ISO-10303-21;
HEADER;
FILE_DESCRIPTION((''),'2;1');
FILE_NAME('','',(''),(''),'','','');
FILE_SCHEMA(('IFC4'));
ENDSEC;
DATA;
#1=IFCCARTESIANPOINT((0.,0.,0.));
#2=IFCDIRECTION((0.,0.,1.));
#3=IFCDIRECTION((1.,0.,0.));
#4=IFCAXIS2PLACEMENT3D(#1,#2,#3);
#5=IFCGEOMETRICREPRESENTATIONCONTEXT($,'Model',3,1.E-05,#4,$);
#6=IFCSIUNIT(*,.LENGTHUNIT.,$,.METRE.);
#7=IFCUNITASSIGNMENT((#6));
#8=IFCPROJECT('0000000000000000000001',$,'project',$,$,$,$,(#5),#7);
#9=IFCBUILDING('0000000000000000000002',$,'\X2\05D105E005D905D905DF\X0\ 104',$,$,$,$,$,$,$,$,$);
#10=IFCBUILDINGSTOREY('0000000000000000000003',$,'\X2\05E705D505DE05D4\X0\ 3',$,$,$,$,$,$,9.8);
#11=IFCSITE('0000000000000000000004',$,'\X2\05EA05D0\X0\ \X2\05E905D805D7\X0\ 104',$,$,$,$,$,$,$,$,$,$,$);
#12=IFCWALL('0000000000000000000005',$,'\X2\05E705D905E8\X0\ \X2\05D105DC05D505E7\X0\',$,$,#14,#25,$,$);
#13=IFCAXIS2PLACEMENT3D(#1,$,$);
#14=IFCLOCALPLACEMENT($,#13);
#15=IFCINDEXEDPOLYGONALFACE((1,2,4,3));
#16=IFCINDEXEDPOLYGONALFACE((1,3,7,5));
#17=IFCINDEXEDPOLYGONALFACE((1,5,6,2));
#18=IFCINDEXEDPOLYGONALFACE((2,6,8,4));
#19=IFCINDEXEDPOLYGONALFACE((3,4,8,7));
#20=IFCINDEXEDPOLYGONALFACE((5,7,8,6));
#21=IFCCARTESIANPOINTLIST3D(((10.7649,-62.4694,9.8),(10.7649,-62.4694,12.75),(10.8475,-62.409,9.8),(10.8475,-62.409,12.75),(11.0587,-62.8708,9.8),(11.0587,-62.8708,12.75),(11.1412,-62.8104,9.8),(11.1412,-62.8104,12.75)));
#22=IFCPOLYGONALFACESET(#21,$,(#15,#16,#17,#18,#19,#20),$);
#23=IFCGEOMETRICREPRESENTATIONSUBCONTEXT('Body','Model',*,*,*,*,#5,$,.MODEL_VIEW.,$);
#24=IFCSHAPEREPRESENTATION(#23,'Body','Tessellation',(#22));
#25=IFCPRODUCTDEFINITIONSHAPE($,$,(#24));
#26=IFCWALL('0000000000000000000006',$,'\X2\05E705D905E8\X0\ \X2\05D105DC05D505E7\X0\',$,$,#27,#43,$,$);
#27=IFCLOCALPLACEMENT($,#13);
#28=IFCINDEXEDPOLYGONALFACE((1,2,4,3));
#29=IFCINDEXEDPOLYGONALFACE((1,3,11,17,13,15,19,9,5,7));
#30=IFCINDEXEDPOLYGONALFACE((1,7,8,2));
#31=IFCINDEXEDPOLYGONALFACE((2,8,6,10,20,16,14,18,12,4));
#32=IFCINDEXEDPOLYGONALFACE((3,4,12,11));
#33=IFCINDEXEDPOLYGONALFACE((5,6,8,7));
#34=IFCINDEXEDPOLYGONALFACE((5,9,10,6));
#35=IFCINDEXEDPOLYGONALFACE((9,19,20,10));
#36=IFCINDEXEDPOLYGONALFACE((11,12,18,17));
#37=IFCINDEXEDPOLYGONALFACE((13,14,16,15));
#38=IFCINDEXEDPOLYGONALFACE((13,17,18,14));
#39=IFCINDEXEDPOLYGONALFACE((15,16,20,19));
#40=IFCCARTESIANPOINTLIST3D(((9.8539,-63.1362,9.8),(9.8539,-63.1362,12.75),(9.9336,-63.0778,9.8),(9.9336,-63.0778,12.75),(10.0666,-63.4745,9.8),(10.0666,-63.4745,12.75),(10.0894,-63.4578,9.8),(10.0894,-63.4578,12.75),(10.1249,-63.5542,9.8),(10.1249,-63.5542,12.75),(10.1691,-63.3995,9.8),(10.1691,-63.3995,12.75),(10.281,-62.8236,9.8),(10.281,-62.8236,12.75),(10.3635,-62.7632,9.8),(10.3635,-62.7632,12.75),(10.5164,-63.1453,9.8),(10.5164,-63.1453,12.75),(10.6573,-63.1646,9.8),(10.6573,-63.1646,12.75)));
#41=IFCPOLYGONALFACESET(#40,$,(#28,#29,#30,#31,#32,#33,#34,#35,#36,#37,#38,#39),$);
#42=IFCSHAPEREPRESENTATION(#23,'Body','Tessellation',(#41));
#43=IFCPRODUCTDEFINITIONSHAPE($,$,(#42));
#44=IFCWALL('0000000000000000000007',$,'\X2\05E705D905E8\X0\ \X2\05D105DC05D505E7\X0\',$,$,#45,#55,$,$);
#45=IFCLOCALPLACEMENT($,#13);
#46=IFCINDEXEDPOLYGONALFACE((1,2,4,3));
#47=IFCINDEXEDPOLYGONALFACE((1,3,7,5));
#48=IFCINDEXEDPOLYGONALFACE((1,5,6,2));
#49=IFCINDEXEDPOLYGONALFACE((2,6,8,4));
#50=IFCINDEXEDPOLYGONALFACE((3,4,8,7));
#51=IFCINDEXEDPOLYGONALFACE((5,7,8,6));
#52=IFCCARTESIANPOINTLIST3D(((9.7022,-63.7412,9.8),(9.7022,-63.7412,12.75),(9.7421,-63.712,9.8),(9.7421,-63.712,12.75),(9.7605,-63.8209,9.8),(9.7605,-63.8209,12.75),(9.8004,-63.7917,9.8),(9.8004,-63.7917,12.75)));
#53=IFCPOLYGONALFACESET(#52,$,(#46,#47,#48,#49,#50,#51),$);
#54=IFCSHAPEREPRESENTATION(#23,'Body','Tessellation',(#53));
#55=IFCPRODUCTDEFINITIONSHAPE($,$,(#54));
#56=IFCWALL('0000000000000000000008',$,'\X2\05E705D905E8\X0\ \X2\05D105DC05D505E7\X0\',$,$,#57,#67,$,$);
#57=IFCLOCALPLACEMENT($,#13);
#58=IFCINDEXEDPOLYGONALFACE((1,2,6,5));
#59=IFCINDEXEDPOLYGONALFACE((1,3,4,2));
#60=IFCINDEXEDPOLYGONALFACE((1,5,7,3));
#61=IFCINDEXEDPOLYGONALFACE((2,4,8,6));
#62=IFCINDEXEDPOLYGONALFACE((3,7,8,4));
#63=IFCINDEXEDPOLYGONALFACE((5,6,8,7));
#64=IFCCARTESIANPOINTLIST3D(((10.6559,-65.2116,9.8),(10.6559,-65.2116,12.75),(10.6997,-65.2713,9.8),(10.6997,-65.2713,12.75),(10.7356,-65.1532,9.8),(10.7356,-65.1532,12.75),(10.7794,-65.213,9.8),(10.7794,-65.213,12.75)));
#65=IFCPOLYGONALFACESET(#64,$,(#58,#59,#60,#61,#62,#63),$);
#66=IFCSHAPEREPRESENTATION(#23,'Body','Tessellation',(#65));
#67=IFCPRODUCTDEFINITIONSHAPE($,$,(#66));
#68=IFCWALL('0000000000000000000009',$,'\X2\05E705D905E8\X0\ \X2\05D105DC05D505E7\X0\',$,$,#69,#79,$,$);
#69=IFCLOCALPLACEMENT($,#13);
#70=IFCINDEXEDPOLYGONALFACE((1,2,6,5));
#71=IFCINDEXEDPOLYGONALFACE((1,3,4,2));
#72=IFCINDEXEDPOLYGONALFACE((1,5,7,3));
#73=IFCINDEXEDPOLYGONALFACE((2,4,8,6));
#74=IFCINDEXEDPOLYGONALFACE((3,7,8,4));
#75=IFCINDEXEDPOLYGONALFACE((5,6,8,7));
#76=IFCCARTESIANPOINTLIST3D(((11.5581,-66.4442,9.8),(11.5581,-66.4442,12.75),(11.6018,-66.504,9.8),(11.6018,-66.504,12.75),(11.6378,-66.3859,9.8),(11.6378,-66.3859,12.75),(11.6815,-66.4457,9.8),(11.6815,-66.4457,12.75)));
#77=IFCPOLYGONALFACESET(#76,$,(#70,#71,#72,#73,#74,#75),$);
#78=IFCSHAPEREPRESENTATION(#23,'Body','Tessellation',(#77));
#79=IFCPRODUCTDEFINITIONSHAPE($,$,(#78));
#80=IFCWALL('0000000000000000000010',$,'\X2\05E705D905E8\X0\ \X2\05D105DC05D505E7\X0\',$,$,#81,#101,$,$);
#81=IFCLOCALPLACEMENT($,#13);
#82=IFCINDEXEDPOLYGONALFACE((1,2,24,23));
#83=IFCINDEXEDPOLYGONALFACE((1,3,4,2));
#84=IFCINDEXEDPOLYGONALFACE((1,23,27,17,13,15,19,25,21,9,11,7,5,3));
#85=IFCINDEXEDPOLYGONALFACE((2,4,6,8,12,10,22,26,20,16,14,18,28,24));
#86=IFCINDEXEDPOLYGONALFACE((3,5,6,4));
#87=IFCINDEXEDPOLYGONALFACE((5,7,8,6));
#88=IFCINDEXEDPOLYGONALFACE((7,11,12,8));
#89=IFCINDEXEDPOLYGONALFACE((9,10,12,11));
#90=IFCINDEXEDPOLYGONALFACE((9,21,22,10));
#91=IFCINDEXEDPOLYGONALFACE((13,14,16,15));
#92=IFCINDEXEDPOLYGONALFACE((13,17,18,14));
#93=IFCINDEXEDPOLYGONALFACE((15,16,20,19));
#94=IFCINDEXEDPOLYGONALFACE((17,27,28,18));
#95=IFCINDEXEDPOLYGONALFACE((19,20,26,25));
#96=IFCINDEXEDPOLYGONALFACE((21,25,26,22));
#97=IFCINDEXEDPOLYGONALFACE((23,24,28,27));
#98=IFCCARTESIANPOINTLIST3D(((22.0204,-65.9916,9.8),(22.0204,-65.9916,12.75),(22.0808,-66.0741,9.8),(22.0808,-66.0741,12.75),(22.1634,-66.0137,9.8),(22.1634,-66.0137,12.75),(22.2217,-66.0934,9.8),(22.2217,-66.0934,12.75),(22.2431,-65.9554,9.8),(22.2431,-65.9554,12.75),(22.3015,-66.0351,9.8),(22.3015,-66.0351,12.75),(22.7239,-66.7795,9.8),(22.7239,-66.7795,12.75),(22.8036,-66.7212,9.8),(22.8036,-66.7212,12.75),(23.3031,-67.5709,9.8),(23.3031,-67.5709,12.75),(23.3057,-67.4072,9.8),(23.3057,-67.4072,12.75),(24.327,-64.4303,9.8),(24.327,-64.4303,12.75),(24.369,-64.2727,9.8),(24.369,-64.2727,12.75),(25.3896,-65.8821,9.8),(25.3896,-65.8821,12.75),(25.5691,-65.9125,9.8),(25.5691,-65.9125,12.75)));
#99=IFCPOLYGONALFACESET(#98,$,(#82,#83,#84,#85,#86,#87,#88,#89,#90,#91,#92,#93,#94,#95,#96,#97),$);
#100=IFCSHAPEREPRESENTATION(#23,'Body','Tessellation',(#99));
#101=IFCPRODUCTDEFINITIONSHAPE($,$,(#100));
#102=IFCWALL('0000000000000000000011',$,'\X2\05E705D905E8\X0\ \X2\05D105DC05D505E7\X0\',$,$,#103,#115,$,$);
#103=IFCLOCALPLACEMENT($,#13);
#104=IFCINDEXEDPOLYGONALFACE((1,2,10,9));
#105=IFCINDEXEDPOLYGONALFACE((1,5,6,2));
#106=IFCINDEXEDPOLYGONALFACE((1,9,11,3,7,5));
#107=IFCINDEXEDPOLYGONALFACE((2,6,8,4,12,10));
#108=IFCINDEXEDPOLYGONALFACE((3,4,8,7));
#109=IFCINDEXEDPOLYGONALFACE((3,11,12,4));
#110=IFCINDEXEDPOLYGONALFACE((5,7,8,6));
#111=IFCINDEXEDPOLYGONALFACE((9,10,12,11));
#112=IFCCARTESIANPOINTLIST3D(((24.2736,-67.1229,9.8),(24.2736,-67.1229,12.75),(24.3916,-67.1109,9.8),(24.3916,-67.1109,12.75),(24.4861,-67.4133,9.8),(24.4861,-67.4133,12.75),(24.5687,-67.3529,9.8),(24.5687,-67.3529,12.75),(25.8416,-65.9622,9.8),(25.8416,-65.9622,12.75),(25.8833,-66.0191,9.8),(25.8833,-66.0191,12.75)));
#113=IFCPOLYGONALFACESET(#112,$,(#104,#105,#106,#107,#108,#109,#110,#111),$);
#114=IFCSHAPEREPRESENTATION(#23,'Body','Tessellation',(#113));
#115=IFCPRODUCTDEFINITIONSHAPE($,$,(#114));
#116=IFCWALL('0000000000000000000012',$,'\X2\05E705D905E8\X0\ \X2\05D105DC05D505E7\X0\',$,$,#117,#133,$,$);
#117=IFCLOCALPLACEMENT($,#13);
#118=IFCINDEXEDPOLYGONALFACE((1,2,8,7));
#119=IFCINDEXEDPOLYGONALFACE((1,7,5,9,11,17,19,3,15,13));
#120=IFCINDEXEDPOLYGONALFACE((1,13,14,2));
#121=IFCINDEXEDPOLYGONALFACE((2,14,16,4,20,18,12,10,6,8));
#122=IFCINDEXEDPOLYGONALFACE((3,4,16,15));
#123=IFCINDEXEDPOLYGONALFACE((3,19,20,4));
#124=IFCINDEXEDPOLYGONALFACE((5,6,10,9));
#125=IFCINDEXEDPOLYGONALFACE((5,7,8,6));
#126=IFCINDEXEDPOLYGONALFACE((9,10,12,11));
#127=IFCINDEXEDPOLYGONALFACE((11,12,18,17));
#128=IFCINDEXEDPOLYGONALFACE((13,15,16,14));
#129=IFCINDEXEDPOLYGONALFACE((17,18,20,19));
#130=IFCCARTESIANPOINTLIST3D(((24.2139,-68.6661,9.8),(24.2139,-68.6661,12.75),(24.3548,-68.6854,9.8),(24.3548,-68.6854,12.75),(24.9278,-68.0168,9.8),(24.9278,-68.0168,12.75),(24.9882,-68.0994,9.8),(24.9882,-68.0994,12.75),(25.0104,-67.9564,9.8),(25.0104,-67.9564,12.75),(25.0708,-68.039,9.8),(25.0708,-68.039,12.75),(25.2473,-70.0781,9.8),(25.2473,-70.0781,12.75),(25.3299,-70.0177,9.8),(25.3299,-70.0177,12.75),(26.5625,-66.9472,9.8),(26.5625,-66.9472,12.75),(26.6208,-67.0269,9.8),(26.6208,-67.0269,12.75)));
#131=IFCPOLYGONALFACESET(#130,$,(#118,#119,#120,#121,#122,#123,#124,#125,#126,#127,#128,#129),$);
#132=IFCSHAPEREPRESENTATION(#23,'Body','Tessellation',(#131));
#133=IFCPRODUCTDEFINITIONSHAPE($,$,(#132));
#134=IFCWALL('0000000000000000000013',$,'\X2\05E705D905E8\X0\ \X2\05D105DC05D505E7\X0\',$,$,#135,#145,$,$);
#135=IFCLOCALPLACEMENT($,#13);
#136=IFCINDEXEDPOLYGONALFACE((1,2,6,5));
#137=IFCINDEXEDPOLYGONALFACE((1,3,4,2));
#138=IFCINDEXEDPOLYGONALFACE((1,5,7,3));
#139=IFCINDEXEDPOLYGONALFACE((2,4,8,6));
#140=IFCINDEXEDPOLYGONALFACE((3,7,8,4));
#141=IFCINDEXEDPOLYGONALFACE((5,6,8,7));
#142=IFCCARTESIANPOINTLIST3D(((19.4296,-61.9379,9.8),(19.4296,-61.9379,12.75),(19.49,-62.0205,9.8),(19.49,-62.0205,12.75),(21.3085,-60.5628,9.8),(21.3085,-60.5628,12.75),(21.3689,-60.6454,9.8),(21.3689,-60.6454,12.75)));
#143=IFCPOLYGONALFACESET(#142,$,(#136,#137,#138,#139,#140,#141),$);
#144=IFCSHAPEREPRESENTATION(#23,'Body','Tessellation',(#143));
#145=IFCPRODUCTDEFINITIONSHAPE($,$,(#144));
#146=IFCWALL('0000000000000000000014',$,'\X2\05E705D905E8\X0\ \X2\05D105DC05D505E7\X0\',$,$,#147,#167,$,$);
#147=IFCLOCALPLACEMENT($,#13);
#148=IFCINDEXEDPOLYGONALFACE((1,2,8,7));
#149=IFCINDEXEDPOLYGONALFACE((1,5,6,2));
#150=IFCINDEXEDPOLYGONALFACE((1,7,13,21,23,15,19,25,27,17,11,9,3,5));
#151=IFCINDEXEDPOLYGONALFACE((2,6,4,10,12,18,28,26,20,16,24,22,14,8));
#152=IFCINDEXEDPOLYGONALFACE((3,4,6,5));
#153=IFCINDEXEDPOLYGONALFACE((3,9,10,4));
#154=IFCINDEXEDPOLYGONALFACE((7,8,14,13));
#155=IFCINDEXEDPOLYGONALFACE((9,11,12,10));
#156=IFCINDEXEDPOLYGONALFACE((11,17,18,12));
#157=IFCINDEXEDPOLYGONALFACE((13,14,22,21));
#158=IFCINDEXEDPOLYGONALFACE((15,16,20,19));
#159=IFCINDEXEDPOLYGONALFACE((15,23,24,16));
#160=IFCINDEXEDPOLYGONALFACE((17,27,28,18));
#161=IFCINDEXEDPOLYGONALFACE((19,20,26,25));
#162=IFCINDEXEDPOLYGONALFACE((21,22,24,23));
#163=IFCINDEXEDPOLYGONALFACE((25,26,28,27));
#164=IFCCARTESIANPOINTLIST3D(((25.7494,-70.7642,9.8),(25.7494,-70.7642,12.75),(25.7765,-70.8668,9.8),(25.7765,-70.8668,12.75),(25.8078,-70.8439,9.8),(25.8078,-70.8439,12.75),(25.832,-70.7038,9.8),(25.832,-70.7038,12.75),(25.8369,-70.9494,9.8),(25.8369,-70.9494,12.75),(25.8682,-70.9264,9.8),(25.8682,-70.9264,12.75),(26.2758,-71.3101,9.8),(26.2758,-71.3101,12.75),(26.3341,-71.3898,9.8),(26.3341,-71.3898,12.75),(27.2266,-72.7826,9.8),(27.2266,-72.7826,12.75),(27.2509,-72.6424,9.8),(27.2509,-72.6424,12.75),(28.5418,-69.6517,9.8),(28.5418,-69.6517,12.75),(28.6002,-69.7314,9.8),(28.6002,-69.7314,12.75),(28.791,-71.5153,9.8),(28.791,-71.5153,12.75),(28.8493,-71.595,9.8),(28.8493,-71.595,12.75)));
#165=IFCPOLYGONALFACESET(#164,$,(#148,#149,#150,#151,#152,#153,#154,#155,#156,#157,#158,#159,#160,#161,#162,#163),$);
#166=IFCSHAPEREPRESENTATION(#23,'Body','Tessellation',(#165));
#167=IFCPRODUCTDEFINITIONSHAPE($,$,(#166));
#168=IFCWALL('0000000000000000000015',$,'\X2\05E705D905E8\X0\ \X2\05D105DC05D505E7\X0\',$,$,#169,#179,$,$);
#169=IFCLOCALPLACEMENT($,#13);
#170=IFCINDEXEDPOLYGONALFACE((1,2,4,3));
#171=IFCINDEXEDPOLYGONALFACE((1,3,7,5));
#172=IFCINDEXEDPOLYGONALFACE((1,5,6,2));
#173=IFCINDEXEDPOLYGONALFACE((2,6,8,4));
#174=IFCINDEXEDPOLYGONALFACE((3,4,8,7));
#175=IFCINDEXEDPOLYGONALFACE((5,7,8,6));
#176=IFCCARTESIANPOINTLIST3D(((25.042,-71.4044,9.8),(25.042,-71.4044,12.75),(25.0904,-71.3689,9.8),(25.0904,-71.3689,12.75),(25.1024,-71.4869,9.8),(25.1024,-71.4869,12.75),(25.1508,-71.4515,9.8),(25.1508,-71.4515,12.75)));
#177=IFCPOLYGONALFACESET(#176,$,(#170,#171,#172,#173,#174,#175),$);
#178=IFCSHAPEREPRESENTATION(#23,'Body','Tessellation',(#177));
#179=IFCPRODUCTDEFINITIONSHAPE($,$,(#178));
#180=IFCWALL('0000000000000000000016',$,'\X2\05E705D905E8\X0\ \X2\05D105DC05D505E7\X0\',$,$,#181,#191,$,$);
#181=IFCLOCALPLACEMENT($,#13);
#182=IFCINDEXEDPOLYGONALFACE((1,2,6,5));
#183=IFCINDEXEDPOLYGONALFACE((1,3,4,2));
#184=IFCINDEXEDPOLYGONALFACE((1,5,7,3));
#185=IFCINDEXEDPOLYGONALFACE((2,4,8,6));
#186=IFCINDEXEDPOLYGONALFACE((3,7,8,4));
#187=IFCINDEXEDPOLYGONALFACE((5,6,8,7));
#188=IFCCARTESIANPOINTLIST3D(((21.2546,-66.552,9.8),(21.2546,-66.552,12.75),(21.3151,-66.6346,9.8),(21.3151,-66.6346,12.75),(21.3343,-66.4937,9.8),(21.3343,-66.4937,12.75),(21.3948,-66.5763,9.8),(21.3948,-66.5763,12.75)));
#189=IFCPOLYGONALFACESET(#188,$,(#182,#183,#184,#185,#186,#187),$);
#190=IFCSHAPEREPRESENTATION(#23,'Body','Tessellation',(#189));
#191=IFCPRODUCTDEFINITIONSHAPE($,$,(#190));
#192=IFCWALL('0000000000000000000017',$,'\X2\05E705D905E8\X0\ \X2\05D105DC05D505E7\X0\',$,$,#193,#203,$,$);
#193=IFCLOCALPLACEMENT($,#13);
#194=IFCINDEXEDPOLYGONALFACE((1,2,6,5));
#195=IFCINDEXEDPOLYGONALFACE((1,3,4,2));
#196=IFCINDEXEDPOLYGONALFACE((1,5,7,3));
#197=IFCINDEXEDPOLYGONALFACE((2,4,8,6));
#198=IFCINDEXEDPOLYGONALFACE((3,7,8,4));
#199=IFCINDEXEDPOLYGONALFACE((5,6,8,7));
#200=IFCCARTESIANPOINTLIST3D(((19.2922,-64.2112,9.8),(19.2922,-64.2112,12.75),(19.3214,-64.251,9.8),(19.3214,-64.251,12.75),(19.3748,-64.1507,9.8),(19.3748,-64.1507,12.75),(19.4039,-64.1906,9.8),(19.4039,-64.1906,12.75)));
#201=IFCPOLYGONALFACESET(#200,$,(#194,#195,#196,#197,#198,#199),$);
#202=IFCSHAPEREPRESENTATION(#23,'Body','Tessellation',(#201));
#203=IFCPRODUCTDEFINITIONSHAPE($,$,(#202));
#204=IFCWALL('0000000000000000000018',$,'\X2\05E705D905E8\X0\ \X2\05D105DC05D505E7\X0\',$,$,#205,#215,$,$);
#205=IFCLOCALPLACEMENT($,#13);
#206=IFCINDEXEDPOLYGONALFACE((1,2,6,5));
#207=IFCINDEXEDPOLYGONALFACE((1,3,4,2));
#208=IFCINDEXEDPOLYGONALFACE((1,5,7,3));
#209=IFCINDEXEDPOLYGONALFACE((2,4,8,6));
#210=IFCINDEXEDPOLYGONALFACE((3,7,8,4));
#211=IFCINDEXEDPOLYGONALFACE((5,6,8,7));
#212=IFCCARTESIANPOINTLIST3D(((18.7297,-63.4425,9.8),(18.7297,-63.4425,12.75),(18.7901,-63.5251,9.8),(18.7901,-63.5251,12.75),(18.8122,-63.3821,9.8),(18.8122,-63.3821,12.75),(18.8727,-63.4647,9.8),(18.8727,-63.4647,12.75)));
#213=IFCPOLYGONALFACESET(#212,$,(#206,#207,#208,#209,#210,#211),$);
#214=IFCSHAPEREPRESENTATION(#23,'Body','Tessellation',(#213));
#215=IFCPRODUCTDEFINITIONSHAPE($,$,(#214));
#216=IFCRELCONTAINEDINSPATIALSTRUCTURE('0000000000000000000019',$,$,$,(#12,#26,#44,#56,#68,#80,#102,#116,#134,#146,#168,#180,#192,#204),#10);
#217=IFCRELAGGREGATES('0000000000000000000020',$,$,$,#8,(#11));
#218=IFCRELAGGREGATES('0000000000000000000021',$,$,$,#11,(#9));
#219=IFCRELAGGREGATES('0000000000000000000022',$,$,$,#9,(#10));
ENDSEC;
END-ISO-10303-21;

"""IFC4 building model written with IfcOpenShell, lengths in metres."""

from ifc_helpers import new_model, si_unit, frame, origin_with_axes, context, subcontext, project, spatial, polyline, outline, extrude, element, save


model = new_model("IFC4")

# Units and contexts
model_context = context("Model", 3, precision=1e-05, world=origin_with_axes())
body_context = subcontext(model_context, "Body", "Model", "MODEL_VIEW")
ifc_project = project(units=[si_unit("LENGTHUNIT", "METRE")], contexts=[model_context])

# Site, building, storey
site = spatial("IfcSite", under=ifc_project, Name="תא שטח 104")
building = spatial("IfcBuilding", under=site, Name="בניין 104")
storey = spatial("IfcBuildingStorey", under=building, Name="קומה 3", Elevation=9.8)

# Walls
element("IfcWall", 1, inside=storey, Name="קיר בלוק", context=body_context, shape_type="SweptSolid", body=[
    extrude(outline(polyline([(11.0587, -62.8708), (11.1412, -62.8104), (10.8475, -62.409), (10.7649, -62.4694), (11.0587, -62.8708)])), frame((0.0, 0.0, 9.8)), (0.0, 0.0, 1.0), 2.95),
])
element("IfcWall", 2, inside=storey, Name="קיר בלוק", context=body_context, shape_type="SweptSolid", body=[
    extrude(outline(polyline([(9.9336, -63.0778), (9.8539, -63.1362), (10.0894, -63.4578), (10.0666, -63.4745), (10.1249, -63.5542), (10.6573, -63.1646), (10.3635, -62.7632), (10.281, -62.8236), (10.5164, -63.1453), (10.1691, -63.3995), (9.9336, -63.0778)])), frame((0.0, 0.0, 9.8)), (0.0, 0.0, 1.0), 2.95),
])
element("IfcWall", 3, inside=storey, Name="קיר בלוק", context=body_context, shape_type="SweptSolid", body=[
    extrude(outline(polyline([(9.7421, -63.712), (9.7022, -63.7412), (9.7605, -63.8209), (9.8004, -63.7917), (9.7421, -63.712)])), frame((0.0, 0.0, 9.8)), (0.0, 0.0, 1.0), 2.95),
])
element("IfcWall", 4, inside=storey, Name="קיר בלוק", context=body_context, shape_type="SweptSolid", body=[
    extrude(outline(polyline([(10.7794, -65.213), (10.7356, -65.1532), (10.6559, -65.2116), (10.6997, -65.2713), (10.7794, -65.213)])), frame((0.0, 0.0, 9.8)), (0.0, 0.0, 1.0), 2.95),
])
element("IfcWall", 5, inside=storey, Name="קיר בלוק", context=body_context, shape_type="SweptSolid", body=[
    extrude(outline(polyline([(11.5581, -66.4442), (11.6018, -66.504), (11.6815, -66.4457), (11.6378, -66.3859), (11.5581, -66.4442)])), frame((0.0, 0.0, 9.8)), (0.0, 0.0, 1.0), 2.95),
])
element("IfcWall", 6, inside=storey, Name="קיר בלוק", context=body_context, shape_type="SweptSolid", body=[
    extrude(outline(polyline([(22.8036, -66.7212), (22.7239, -66.7795), (23.3031, -67.5709), (25.5691, -65.9125), (24.369, -64.2727), (22.0204, -65.9916), (22.0808, -66.0741), (22.1634, -66.0137), (22.2217, -66.0934), (22.3015, -66.0351), (22.2431, -65.9554), (24.327, -64.4303), (25.3896, -65.8821), (23.3057, -67.4072), (22.8036, -66.7212)])), frame((0.0, 0.0, 9.8)), (0.0, 0.0, 1.0), 2.95),
])
element("IfcWall", 7, inside=storey, Name="קיר בלוק", context=body_context, shape_type="SweptSolid", body=[
    extrude(outline(polyline([(24.2736, -67.1229), (24.4861, -67.4133), (24.5687, -67.3529), (24.3916, -67.1109), (25.8833, -66.0191), (25.8416, -65.9622), (24.2736, -67.1229)])), frame((0.0, 0.0, 9.8)), (0.0, 0.0, 1.0), 2.95),
])
element("IfcWall", 8, inside=storey, Name="קיר בלוק", context=body_context, shape_type="SweptSolid", body=[
    extrude(outline(polyline([(25.0104, -67.9564), (24.9278, -68.0168), (24.9882, -68.0994), (24.2139, -68.6661), (25.2473, -70.0781), (25.3299, -70.0177), (24.3548, -68.6854), (26.6208, -67.0269), (26.5625, -66.9472), (25.0708, -68.039), (25.0104, -67.9564)])), frame((0.0, 0.0, 9.8)), (0.0, 0.0, 1.0), 2.95),
])
element("IfcWall", 9, inside=storey, Name="קיר בלוק", context=body_context, shape_type="SweptSolid", body=[
    extrude(outline(polyline([(21.3085, -60.5628), (19.4296, -61.9379), (19.49, -62.0205), (21.3689, -60.6454), (21.3085, -60.5628)])), frame((0.0, 0.0, 9.8)), (0.0, 0.0, 1.0), 2.95),
])
element("IfcWall", 10, inside=storey, Name="קיר בלוק", context=body_context, shape_type="SweptSolid", body=[
    extrude(outline(polyline([(25.7765, -70.8668), (25.8369, -70.9494), (25.8682, -70.9264), (27.2266, -72.7826), (28.8493, -71.595), (28.791, -71.5153), (27.2509, -72.6424), (26.3341, -71.3898), (28.6002, -69.7314), (28.5418, -69.6517), (26.2758, -71.3101), (25.832, -70.7038), (25.7494, -70.7642), (25.8078, -70.8439), (25.7765, -70.8668)])), frame((0.0, 0.0, 9.8)), (0.0, 0.0, 1.0), 2.95),
])
element("IfcWall", 11, inside=storey, Name="קיר בלוק", context=body_context, shape_type="SweptSolid", body=[
    extrude(outline(polyline([(25.0904, -71.3689), (25.042, -71.4044), (25.1024, -71.4869), (25.1508, -71.4515), (25.0904, -71.3689)])), frame((0.0, 0.0, 9.8)), (0.0, 0.0, 1.0), 2.95),
])
element("IfcWall", 12, inside=storey, Name="קיר בלוק", context=body_context, shape_type="SweptSolid", body=[
    extrude(outline(polyline([(21.3948, -66.5763), (21.3343, -66.4937), (21.2546, -66.552), (21.3151, -66.6346), (21.3948, -66.5763)])), frame((0.0, 0.0, 9.8)), (0.0, 0.0, 1.0), 2.95),
])
element("IfcWall", 13, inside=storey, Name="קיר בלוק", context=body_context, shape_type="SweptSolid", body=[
    extrude(outline(polyline([(19.3214, -64.251), (19.4039, -64.1906), (19.3748, -64.1507), (19.2922, -64.2112), (19.3214, -64.251)])), frame((0.0, 0.0, 9.8)), (0.0, 0.0, 1.0), 2.95),
])
element("IfcWall", 14, inside=storey, Name="קיר בלוק", context=body_context, shape_type="SweptSolid", body=[
    extrude(outline(polyline([(18.8727, -63.4647), (18.8122, -63.3821), (18.7297, -63.4425), (18.7901, -63.5251), (18.8727, -63.4647)])), frame((0.0, 0.0, 9.8)), (0.0, 0.0, 1.0), 2.95),
])

save(model, "model.ifc")
